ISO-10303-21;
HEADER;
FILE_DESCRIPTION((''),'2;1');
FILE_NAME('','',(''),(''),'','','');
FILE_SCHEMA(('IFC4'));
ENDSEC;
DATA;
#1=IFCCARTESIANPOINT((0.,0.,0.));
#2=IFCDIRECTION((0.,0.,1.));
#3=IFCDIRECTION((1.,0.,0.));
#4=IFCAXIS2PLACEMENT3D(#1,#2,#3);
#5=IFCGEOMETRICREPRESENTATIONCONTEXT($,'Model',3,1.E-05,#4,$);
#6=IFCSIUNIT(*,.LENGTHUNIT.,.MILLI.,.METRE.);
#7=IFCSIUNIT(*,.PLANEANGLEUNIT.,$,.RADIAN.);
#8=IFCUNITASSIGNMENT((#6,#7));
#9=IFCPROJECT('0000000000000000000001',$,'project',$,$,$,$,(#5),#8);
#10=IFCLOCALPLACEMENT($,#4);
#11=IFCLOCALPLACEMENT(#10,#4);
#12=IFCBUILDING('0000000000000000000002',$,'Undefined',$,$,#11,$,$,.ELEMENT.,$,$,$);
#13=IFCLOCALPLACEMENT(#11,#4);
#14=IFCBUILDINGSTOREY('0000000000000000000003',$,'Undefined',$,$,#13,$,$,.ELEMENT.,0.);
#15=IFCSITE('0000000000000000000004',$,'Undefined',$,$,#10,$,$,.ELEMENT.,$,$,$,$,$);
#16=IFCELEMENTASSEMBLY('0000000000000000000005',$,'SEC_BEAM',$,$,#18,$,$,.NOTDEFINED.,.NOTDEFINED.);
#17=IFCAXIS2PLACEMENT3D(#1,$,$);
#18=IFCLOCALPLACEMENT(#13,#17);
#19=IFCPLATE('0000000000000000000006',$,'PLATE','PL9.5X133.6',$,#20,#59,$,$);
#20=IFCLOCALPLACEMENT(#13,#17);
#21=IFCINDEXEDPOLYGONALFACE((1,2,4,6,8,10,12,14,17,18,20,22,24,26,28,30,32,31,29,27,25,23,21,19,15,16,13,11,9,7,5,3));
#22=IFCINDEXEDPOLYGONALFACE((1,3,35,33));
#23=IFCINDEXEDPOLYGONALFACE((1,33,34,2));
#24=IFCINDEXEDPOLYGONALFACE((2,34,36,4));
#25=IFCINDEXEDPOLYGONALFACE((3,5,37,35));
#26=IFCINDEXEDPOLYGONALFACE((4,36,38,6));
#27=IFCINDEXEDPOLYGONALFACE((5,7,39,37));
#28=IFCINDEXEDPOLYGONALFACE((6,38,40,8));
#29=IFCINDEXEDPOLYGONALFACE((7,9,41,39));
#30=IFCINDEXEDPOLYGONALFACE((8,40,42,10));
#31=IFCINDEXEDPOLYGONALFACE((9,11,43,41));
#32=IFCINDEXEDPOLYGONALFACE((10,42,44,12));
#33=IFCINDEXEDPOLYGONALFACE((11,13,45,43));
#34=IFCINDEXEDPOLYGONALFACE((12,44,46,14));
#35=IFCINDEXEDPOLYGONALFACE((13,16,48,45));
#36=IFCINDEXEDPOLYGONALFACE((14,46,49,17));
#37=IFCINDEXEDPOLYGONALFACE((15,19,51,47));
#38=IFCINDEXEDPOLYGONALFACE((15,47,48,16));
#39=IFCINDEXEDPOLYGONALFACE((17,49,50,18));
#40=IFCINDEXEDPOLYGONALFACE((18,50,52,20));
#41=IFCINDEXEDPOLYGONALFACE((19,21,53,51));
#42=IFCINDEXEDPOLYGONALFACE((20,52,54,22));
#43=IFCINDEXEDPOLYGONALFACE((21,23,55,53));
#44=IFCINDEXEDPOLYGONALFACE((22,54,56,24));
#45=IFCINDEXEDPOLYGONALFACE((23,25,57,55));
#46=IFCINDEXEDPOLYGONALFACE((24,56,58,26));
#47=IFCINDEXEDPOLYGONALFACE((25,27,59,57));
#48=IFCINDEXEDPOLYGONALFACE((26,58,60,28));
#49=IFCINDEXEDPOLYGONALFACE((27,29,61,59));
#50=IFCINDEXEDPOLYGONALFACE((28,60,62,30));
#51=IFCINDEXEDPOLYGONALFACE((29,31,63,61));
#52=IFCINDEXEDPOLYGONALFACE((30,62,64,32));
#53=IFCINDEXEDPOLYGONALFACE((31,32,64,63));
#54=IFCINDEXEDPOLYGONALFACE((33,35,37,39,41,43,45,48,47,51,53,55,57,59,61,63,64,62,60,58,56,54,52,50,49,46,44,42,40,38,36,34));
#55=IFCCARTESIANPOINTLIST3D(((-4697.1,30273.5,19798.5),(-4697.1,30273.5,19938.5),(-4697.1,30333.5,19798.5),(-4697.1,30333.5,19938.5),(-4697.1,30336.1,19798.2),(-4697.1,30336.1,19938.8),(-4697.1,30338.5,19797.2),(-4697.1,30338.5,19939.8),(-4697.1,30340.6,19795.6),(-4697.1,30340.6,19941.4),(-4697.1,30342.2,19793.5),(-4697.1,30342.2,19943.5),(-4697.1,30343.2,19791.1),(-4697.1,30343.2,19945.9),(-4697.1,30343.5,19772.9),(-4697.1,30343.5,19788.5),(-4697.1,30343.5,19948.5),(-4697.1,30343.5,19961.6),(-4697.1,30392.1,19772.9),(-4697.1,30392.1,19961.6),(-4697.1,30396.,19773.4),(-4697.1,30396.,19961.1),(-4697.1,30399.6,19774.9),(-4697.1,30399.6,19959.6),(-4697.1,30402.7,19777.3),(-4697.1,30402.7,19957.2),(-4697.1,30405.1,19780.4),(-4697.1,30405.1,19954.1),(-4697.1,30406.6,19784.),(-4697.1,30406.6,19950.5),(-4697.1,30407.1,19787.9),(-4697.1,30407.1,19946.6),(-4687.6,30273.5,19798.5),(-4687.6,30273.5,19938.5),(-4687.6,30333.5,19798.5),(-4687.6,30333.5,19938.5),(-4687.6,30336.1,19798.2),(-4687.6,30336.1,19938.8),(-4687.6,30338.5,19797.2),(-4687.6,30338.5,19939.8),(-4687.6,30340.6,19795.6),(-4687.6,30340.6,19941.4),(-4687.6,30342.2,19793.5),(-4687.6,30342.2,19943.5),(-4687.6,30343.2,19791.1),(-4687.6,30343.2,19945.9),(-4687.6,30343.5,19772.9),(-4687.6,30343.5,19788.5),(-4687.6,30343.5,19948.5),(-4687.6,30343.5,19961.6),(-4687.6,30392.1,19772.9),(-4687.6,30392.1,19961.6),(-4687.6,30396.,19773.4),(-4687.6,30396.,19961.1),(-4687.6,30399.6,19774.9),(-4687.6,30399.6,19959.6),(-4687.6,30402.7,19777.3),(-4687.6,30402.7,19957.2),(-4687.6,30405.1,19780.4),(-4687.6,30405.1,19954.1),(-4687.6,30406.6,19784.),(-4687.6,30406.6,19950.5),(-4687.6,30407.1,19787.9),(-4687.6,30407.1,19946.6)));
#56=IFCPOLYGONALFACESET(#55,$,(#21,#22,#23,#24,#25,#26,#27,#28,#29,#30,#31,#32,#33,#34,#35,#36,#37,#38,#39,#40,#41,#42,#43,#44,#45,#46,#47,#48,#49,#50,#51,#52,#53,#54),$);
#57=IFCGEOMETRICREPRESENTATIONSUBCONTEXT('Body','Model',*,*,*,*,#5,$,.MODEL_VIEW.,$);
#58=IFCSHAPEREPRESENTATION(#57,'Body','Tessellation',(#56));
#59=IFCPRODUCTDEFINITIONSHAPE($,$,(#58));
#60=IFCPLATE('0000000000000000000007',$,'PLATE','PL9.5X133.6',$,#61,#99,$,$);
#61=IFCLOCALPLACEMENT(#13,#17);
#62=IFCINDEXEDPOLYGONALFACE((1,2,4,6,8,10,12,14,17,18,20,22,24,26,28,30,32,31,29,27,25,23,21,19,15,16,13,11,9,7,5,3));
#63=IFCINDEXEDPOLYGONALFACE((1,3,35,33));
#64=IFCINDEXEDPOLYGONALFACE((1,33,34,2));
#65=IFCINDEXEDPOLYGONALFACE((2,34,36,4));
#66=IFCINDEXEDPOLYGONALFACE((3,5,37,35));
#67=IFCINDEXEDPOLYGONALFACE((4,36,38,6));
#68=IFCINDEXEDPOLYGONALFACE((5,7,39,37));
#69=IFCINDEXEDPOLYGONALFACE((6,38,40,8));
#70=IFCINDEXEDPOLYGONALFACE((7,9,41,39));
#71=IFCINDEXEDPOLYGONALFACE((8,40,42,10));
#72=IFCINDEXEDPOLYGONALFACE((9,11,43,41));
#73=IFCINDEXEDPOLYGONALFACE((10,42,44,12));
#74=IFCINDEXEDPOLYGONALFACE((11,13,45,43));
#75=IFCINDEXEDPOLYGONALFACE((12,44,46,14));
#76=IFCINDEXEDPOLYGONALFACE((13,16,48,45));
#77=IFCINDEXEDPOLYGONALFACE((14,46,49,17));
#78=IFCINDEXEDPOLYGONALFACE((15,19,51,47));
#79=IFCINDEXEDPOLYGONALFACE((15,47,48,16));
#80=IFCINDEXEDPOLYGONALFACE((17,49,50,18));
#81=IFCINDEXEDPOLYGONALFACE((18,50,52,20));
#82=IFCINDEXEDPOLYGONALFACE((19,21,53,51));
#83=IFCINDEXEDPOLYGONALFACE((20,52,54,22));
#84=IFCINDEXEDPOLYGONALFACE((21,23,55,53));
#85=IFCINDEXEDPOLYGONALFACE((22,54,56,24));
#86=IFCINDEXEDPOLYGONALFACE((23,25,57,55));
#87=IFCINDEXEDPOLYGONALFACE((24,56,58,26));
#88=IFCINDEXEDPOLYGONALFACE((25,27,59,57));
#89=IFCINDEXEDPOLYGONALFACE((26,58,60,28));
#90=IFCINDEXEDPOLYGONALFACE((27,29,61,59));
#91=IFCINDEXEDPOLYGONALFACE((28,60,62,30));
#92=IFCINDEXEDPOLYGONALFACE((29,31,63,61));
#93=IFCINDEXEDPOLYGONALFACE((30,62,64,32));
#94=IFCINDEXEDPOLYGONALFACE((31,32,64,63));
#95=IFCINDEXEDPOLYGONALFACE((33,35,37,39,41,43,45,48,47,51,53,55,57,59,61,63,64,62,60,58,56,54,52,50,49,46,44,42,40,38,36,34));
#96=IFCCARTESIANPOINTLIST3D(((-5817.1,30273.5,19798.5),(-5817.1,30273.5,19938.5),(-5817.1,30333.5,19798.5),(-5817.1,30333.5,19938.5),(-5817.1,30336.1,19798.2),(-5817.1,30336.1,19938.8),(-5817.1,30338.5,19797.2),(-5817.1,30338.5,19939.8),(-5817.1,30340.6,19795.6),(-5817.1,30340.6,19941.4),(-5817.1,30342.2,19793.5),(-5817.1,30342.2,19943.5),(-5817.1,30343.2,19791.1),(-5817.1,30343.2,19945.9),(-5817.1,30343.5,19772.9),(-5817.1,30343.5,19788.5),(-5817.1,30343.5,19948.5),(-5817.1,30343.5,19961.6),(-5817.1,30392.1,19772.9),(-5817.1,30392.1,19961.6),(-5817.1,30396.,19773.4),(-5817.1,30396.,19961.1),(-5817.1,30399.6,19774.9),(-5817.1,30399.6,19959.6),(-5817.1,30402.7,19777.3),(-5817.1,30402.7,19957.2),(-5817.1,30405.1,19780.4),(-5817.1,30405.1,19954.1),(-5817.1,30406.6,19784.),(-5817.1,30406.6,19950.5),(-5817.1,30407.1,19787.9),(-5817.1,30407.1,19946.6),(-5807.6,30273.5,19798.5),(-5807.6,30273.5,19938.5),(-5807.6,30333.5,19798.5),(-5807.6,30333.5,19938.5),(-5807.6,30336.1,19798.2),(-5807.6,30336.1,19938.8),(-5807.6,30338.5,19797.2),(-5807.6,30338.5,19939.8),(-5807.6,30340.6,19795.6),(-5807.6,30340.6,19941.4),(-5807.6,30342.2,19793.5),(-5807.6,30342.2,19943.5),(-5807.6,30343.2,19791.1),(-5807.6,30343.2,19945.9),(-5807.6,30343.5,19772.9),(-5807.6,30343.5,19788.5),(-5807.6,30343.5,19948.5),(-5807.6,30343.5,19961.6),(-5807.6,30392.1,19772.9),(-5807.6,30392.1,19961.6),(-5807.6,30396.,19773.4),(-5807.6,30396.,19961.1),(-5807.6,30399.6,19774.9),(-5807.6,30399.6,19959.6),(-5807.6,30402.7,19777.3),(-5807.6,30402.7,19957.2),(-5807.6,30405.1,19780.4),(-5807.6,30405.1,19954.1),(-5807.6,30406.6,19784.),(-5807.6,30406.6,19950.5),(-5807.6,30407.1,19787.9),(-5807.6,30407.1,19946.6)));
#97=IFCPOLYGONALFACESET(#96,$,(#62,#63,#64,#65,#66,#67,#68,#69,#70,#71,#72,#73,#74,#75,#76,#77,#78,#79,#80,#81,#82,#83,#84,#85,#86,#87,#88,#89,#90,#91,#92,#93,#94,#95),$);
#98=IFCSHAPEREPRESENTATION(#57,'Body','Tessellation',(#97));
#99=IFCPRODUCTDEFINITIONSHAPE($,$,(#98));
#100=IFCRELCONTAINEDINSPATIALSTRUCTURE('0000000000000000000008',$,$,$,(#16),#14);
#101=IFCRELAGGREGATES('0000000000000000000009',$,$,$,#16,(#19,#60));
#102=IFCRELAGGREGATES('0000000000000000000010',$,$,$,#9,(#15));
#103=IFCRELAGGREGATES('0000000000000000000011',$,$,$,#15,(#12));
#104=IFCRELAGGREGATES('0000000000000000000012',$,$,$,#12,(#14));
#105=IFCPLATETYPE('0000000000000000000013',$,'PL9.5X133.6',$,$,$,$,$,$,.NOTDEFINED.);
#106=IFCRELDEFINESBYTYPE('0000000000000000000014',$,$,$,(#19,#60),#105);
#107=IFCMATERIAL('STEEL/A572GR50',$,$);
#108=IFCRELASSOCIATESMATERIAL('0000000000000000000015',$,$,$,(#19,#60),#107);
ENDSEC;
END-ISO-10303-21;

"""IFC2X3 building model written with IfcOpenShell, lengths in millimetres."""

from ifc_helpers import new_model, si_unit, frame, frame_2d, origin_with_axes, place, context, subcontext, project, spatial, polyline, circle_curve, parameter, trimmed, segment, composite_curve, outline, extrude, material, type_object, element, aggregate, save


model = new_model("IFC2X3")

# Units and contexts
model_context = context("Model", 3, precision=1e-05, world=origin_with_axes())
body_context = subcontext(model_context, "Body", "Model", "MODEL_VIEW")
ifc_project = project(units=[si_unit("LENGTHUNIT", "METRE", prefix="MILLI"), si_unit("PLANEANGLEUNIT", "RADIAN")], contexts=[model_context])

# Site, building, storey
site_placement = place(None, origin_with_axes())
site = spatial("IfcSite", under=ifc_project, at=site_placement, Name="Undefined", CompositionType="ELEMENT")
building_placement = place(site_placement, origin_with_axes())
building = spatial("IfcBuilding", under=site, at=building_placement, Name="Undefined", CompositionType="ELEMENT")
storey_placement = place(building_placement, origin_with_axes())
storey = spatial("IfcBuildingStorey", under=building, at=storey_placement, Name="Undefined", CompositionType="ELEMENT", Elevation=0.0)

# Element assembly
ifc_material_1 = material(Name="STEEL/A572GR50")
assembly_1_placement = place(storey_placement, origin_with_axes())
assembly_1 = element("IfcElementAssembly", 1, at=assembly_1_placement, inside=storey, Name="SEC_BEAM", AssemblyPlace="NOTDEFINED", PredefinedType="NOTDEFINED")

# Plates
plate_type_1 = type_object("IfcPlateType", Name="PL9.5X133.6", PredefinedType="NOTDEFINED")
plate_1_placement = place(assembly_1_placement, frame((-4692.3, 30407.1, 19961.6), z_axis=(-1.0, 0.0, 0.0), x_axis=(0.0, 0.0, -1.0)))
plate_1 = element("IfcPlate", 2, at=plate_1_placement, type_object=plate_type_1, material=ifc_material_1, Name="PLATE", Description="PL9.5X133.6", context=body_context, shape_type="SweptSolid", body=[
    extrude(outline(composite_curve([segment(trimmed(circle_curve(frame_2d((15.0, 15.0), x_axis=(-1.0, 0.0)), 15.0), [parameter(0.0)], [parameter(1.570796)], True, "PARAMETER"), True, "CONTINUOUS"), segment(polyline([(15.0, 0.0), (173.7, 0.0)]), True, "CONTINUOUS"), segment(trimmed(circle_curve(frame_2d((173.7, 15.0), x_axis=(0.0, -1.0)), 15.0), [parameter(0.0)], [parameter(1.570796)], True, "PARAMETER"), True, "CONTINUOUS"), segment(polyline([(188.7, 15.0), (188.7, 63.6), (173.1, 63.6)]), True, "CONTINUOUS"), segment(trimmed(circle_curve(frame_2d((173.1, 73.6), x_axis=(0.0, -1.0)), 10.0), [parameter(0.0)], [parameter(4.712389)], False, "PARAMETER"), True, "CONTINUOUS"), segment(polyline([(163.1, 73.6), (163.1, 133.6), (23.1, 133.6), (23.1, 73.6)]), True, "CONTINUOUS"), segment(trimmed(circle_curve(frame_2d((13.1, 73.6), x_axis=(1.0, 0.0)), 10.0), [parameter(0.0)], [parameter(4.712389)], False, "PARAMETER"), True, "CONTINUOUS"), segment(polyline([(13.1, 63.6), (0.0, 63.6), (0.0, 15.0)]), True, "CONTINUOUS")], self_intersect=True)), frame((0.0, 0.0, -4.8), z_axis=(0.0, 0.0, 1.0), x_axis=(1.0, 0.0, 0.0)), (0.0, 0.0, 1.0), 9.5),
])
plate_2_placement = place(assembly_1_placement, frame((-5812.3, 30407.1, 19961.6), z_axis=(-1.0, 0.0, 0.0), x_axis=(0.0, 0.0, -1.0)))
plate_2 = element("IfcPlate", 3, at=plate_2_placement, type_object=plate_type_1, material=ifc_material_1, Name="PLATE", Description="PL9.5X133.6", context=body_context, shape_type="SweptSolid", body=[
    extrude(outline(composite_curve([segment(trimmed(circle_curve(frame_2d((15.0, 15.0), x_axis=(-1.0, 0.0)), 15.0), [parameter(0.0)], [parameter(1.570796)], True, "PARAMETER"), True, "CONTINUOUS"), segment(polyline([(15.0, 0.0), (173.7, 0.0)]), True, "CONTINUOUS"), segment(trimmed(circle_curve(frame_2d((173.7, 15.0), x_axis=(0.0, -1.0)), 15.0), [parameter(0.0)], [parameter(1.570796)], True, "PARAMETER"), True, "CONTINUOUS"), segment(polyline([(188.7, 15.0), (188.7, 63.6), (173.1, 63.6)]), True, "CONTINUOUS"), segment(trimmed(circle_curve(frame_2d((173.1, 73.6), x_axis=(0.0, -1.0)), 10.0), [parameter(0.0)], [parameter(4.712389)], False, "PARAMETER"), True, "CONTINUOUS"), segment(polyline([(163.1, 73.6), (163.1, 133.6), (23.1, 133.6), (23.1, 73.6)]), True, "CONTINUOUS"), segment(trimmed(circle_curve(frame_2d((13.1, 73.6), x_axis=(1.0, 0.0)), 10.0), [parameter(0.0)], [parameter(4.712389)], False, "PARAMETER"), True, "CONTINUOUS"), segment(polyline([(13.1, 63.6), (0.0, 63.6), (0.0, 15.0)]), True, "CONTINUOUS")], self_intersect=True)), frame((0.0, 0.0, -4.8), z_axis=(0.0, 0.0, 1.0), x_axis=(1.0, 0.0, 0.0)), (0.0, 0.0, 1.0), 9.5),
])

aggregate(assembly_1, [plate_1, plate_2])

save(model, "model.ifc")
